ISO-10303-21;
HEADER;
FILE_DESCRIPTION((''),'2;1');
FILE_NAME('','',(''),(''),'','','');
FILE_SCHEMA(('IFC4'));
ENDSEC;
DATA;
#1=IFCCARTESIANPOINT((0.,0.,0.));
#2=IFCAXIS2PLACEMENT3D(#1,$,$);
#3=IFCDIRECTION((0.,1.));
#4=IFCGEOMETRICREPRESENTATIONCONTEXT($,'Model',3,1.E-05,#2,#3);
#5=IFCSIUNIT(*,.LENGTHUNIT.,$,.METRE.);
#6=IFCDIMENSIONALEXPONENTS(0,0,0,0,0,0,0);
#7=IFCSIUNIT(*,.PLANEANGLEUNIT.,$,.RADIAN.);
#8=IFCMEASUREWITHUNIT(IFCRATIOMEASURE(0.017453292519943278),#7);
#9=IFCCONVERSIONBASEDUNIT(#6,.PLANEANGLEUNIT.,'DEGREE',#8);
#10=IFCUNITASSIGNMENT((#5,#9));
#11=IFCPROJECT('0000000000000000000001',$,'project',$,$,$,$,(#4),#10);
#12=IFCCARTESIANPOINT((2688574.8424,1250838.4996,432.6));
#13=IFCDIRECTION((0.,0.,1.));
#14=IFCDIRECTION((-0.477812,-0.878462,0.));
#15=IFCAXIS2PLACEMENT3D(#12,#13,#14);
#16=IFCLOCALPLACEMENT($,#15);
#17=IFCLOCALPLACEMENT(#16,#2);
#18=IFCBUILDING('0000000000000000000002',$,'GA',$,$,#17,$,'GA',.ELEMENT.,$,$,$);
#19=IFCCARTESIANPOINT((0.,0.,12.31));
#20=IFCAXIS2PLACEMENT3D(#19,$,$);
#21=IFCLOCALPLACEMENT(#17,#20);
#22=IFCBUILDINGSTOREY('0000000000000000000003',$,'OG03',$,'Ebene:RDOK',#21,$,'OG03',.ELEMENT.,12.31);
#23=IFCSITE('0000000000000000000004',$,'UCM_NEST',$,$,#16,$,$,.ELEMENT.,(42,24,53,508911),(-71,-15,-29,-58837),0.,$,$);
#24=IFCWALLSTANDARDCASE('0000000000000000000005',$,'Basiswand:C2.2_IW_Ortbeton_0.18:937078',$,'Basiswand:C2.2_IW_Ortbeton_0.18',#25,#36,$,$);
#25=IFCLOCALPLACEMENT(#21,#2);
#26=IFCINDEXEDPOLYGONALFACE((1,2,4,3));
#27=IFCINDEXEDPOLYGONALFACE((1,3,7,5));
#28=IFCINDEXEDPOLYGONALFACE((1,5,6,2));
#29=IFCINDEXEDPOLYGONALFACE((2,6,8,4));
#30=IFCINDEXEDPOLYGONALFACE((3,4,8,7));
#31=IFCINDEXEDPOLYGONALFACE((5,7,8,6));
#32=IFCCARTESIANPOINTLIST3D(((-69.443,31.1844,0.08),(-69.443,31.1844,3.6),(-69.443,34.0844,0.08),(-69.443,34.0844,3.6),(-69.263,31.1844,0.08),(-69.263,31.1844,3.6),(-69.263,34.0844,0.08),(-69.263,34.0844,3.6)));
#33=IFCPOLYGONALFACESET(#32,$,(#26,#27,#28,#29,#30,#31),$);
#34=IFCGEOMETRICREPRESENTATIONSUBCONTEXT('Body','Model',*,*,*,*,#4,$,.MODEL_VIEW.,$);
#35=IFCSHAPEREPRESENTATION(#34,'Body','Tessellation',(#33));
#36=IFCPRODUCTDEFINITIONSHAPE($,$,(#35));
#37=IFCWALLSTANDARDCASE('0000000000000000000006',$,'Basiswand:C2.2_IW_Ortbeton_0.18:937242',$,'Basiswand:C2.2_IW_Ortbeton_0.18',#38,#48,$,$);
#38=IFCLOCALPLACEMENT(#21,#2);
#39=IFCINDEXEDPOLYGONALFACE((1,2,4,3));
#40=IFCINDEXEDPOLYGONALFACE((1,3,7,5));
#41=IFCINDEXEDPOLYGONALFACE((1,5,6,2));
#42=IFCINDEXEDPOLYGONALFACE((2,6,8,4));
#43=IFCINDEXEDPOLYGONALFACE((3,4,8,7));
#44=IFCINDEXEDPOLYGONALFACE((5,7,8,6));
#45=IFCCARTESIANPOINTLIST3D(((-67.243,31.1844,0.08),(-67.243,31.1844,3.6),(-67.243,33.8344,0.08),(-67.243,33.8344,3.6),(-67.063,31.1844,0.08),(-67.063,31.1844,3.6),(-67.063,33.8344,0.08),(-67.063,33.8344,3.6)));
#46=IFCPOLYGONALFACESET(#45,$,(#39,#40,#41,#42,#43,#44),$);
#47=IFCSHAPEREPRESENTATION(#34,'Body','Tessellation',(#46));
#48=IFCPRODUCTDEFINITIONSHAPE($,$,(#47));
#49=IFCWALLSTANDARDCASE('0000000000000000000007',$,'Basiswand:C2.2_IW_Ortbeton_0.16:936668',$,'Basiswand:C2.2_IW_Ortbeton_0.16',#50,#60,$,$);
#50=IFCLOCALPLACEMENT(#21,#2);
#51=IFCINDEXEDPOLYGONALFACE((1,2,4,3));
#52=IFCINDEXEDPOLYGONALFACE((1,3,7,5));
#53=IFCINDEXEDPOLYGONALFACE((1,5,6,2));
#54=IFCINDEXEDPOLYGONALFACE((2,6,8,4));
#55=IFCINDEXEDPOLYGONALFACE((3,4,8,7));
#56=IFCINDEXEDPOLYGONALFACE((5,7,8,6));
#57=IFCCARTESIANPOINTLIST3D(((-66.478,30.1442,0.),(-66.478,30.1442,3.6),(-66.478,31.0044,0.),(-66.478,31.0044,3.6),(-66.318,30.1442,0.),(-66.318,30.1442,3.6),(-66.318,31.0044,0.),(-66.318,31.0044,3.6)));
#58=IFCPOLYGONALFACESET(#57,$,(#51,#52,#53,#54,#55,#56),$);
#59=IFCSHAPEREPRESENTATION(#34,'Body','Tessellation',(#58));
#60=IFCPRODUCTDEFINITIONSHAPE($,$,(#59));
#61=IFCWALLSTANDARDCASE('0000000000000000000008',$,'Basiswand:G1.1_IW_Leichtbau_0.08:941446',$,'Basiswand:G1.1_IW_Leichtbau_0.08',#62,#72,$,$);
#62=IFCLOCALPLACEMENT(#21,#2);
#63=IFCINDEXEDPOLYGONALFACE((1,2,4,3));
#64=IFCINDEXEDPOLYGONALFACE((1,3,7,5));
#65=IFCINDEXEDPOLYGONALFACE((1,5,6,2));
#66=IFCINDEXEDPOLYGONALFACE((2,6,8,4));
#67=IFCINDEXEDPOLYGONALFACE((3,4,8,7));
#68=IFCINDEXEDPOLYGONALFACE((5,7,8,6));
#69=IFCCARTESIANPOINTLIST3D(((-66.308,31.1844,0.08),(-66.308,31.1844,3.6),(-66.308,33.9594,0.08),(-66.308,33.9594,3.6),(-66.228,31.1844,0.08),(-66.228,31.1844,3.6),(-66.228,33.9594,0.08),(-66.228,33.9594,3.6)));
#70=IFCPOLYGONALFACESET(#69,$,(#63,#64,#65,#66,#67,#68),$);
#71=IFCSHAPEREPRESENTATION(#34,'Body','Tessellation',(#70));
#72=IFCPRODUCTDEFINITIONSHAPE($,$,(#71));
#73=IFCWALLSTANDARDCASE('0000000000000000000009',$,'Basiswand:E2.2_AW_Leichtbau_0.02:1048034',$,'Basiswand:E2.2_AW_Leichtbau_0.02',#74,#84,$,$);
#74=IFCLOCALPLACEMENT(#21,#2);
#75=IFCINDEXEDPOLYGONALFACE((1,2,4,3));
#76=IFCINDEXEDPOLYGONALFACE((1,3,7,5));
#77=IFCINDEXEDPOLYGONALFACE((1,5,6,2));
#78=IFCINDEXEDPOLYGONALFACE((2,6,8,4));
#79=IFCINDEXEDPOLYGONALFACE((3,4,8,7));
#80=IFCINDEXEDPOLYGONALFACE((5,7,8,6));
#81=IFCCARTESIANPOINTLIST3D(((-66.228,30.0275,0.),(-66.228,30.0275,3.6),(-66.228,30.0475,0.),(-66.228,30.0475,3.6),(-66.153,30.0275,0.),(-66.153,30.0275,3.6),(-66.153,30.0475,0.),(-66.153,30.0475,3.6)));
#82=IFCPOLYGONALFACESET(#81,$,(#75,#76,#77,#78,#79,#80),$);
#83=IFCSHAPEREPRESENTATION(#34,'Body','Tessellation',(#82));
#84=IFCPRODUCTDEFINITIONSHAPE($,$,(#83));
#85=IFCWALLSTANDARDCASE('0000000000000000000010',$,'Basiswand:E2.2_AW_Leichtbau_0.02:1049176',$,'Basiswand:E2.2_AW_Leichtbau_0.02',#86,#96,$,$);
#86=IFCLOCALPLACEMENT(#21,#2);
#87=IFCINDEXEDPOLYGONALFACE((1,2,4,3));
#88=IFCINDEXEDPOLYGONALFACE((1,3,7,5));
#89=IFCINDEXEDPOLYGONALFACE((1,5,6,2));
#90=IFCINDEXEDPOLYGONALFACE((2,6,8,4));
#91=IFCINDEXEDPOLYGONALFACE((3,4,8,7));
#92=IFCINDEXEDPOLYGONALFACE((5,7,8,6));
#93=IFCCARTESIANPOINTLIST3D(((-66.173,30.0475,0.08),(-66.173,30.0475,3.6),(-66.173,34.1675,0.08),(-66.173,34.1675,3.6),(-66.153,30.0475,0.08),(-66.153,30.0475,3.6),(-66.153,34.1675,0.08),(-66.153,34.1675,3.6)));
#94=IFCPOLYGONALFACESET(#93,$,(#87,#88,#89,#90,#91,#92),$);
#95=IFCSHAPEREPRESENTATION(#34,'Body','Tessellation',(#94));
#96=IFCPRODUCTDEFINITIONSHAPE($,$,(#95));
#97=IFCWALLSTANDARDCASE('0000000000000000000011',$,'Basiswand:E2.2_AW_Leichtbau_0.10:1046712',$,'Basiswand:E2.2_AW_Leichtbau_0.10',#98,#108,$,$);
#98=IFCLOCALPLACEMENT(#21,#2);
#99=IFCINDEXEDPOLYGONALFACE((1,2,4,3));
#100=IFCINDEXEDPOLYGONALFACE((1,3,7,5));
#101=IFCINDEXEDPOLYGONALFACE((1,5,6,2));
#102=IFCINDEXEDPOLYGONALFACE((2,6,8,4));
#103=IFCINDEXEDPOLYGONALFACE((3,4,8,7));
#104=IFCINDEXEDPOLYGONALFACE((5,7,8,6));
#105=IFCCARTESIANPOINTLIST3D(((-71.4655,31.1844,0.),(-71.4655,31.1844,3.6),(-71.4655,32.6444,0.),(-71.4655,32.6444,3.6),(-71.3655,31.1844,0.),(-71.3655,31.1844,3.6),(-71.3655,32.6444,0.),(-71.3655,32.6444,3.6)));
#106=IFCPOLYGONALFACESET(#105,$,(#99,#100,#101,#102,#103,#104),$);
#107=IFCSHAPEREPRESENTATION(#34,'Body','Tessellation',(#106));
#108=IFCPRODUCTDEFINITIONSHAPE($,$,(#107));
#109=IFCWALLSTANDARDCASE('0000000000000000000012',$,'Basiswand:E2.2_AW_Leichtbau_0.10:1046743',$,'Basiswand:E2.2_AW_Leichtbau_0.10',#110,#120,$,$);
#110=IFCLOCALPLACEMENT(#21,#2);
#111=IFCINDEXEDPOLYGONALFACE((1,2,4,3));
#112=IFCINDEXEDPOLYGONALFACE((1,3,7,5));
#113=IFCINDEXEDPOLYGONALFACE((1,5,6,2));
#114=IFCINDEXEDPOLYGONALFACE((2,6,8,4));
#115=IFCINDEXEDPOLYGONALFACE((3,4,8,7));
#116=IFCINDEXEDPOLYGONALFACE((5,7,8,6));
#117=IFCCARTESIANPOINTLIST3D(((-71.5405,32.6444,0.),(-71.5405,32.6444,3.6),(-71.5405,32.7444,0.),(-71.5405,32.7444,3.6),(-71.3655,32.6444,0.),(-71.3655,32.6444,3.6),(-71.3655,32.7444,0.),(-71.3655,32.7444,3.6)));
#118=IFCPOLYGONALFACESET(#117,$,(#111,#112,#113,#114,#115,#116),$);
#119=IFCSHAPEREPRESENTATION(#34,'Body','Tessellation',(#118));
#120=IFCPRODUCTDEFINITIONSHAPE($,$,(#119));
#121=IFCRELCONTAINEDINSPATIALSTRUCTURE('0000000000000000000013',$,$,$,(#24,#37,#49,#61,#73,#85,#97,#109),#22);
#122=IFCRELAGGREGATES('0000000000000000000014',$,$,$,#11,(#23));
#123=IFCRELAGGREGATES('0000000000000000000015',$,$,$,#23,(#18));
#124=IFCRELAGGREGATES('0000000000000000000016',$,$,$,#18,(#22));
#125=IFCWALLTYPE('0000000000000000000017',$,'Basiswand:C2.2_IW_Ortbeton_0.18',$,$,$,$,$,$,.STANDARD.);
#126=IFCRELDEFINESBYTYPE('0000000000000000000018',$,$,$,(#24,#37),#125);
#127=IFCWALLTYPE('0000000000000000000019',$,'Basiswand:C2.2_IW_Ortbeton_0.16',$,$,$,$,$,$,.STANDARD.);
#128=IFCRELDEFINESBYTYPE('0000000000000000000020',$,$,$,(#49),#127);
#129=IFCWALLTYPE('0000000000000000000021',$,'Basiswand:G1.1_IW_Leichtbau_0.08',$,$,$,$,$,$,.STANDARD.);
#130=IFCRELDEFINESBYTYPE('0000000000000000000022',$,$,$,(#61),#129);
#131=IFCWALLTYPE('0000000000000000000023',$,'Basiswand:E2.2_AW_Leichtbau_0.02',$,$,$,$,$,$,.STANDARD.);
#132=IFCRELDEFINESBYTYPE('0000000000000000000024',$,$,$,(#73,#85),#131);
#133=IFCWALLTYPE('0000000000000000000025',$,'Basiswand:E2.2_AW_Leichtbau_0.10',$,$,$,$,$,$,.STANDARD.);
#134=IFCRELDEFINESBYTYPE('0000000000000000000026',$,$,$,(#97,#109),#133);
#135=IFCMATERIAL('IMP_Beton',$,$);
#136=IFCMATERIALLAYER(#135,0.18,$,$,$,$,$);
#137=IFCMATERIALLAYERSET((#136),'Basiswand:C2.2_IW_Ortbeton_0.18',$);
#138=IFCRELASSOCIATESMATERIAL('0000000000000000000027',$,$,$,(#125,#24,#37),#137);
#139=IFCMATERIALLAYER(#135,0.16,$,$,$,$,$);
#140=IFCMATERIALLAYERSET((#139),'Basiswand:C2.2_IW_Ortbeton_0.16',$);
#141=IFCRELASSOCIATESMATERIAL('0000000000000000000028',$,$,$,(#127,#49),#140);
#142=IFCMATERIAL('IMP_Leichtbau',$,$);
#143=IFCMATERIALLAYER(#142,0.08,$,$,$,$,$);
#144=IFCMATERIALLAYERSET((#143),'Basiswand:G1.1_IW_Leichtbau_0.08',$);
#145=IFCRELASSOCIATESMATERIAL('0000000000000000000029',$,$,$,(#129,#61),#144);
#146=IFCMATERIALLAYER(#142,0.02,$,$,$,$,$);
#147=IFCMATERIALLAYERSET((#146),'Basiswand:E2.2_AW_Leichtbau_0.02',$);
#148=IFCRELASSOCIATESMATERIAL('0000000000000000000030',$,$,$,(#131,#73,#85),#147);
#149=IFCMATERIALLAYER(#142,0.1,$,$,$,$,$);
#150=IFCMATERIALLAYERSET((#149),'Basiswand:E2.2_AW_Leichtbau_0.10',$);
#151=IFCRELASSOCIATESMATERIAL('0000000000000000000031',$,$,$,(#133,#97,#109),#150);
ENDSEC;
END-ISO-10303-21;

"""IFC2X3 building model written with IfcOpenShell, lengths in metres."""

from ifc_helpers import new_model, entity, si_unit, converted_unit, direction, frame, frame_2d, origin, place, context, subcontext, project, spatial, polyline, rectangle, extrude, clip, bounded_halfspace, material, layer, layer_set, layer_usage, type_object, element, save


model = new_model("IFC2X3")

# Units and contexts
model_context = context("Model", 3, precision=1e-05, world=origin(), true_north=direction((0.0, 1.0)))
body_context = subcontext(model_context, "Body", "Model", "MODEL_VIEW")
ifc_project = project(units=[si_unit("LENGTHUNIT", "METRE"), converted_unit("PLANEANGLEUNIT", "DEGREE", entity("IfcRatioMeasure", 0.017453292519943278), si_unit("PLANEANGLEUNIT", "RADIAN"), dimensions=[0, 0, 0, 0, 0, 0, 0])], contexts=[model_context])

# Site, building, storey
site_placement = place(None, frame((2688574.8424, 1250838.4996, 432.6), z_axis=(0.0, 0.0, 1.0), x_axis=(-0.477812, -0.878462, 0.0)))
site = spatial("IfcSite", under=ifc_project, at=site_placement, Name="UCM_NEST", CompositionType="ELEMENT", RefLatitude=(42, 24, 53, 508911), RefLongitude=(-71, -15, -29, -58837), RefElevation=0.0)
building_placement = place(site_placement, origin())
building = spatial("IfcBuilding", under=site, at=building_placement, Name="GA", LongName="GA", CompositionType="ELEMENT")
storey_placement = place(building_placement, frame((0.0, 0.0, 12.31)))
storey = spatial("IfcBuildingStorey", under=building, at=storey_placement, Name="OG03", ObjectType="Ebene:RDOK", LongName="OG03", CompositionType="ELEMENT", Elevation=12.31)

# Shared definitions
ifc_material_1 = material(Name="IMP_Beton")

# Walls
ifc_material_2 = material(Name="IMP_Leichtbau")
ifc_layer_1 = layer(ifc_material_1, 0.18)
ifc_layer_set_1 = layer_set([ifc_layer_1], Name="Basiswand:C2.2_IW_Ortbeton_0.18")
ifc_layer_usage_1 = layer_usage(ifc_layer_set_1, "AXIS2", "NEGATIVE", 0.09)
wall_type_1 = type_object("IfcWallType", Name="Basiswand:C2.2_IW_Ortbeton_0.18", PredefinedType="STANDARD", material=ifc_layer_set_1)
wall_1_placement = place(storey_placement, frame((-69.353, 31.1844, 0.08), z_axis=(0.0, 0.0, 1.0), x_axis=(0.0, 1.0, 0.0)))
element("IfcWallStandardCase", 1, at=wall_1_placement, inside=storey, type_object=wall_type_1, material=ifc_layer_usage_1, Name="Basiswand:C2.2_IW_Ortbeton_0.18:937078", ObjectType="Basiswand:C2.2_IW_Ortbeton_0.18", context=body_context, shape_type="Clipping", body=[
    clip(extrude(rectangle(XDim=2.9, YDim=0.18, at=frame_2d((1.45, 0.0), x_axis=(-1.0, 0.0))), origin(), (0.0, 0.0, 1.0), 3.52), bounded_halfspace(frame((2.9, -0.09, 0.0), z_axis=(0.0, 0.0, 1.0), x_axis=(0.0, 1.0, 0.0)), True, frame((2.9, -0.09, 0.0), z_axis=(0.0, 0.0, 1.0), x_axis=(0.0, 1.0, 0.0)), polyline([(0.0, 0.0), (0.18, 0.0), (0.18, 2.9), (0.0, 2.9), (0.0, 0.25), (0.0, 0.0)]))),
])
wall_2_placement = place(storey_placement, frame((-67.153, 33.8344, 0.08), z_axis=(0.0, 0.0, 1.0), x_axis=(0.0, -1.0, 0.0)))
element("IfcWallStandardCase", 2, at=wall_2_placement, inside=storey, type_object=wall_type_1, material=ifc_layer_usage_1, Name="Basiswand:C2.2_IW_Ortbeton_0.18:937242", ObjectType="Basiswand:C2.2_IW_Ortbeton_0.18", context=body_context, shape_type="Clipping", body=[
    clip(extrude(rectangle(XDim=2.65, YDim=0.18, at=frame_2d((1.325, 0.0), x_axis=(-1.0, 0.0))), origin(), (0.0, 0.0, 1.0), 3.52), bounded_halfspace(frame((2.65, -0.09, 0.0), z_axis=(0.0, 0.0, 1.0), x_axis=(0.0, -1.0, 0.0)), True, frame((2.65, -0.09, 0.0), z_axis=(0.0, 0.0, 1.0), x_axis=(0.0, -1.0, 0.0)), polyline([(0.0, 0.0), (-0.18, 0.0), (-0.18, -2.65), (0.0, -2.65), (0.0, 0.0)]))),
])
ifc_layer_2 = layer(ifc_material_1, 0.16)
ifc_layer_set_2 = layer_set([ifc_layer_2], Name="Basiswand:C2.2_IW_Ortbeton_0.16")
ifc_layer_usage_2 = layer_usage(ifc_layer_set_2, "AXIS2", "NEGATIVE", 0.08)
wall_type_2 = type_object("IfcWallType", Name="Basiswand:C2.2_IW_Ortbeton_0.16", PredefinedType="STANDARD", material=ifc_layer_set_2)
wall_3_placement = place(storey_placement, frame((-66.398, 31.0044, 0.0), z_axis=(0.0, 0.0, 1.0), x_axis=(0.0, -1.0, 0.0)))
element("IfcWallStandardCase", 3, at=wall_3_placement, inside=storey, type_object=wall_type_2, material=ifc_layer_usage_2, Name="Basiswand:C2.2_IW_Ortbeton_0.16:936668", ObjectType="Basiswand:C2.2_IW_Ortbeton_0.16", context=body_context, shape_type="SweptSolid", body=[
    extrude(rectangle(XDim=0.8603, YDim=0.16, at=frame_2d((0.4301, 0.0), x_axis=(-1.0, 0.0))), origin(), (0.0, 0.0, 1.0), 3.6),
])
ifc_layer_3 = layer(ifc_material_2, 0.08)
ifc_layer_set_3 = layer_set([ifc_layer_3], Name="Basiswand:G1.1_IW_Leichtbau_0.08")
ifc_layer_usage_3 = layer_usage(ifc_layer_set_3, "AXIS2", "NEGATIVE", 0.04)
wall_type_3 = type_object("IfcWallType", Name="Basiswand:G1.1_IW_Leichtbau_0.08", PredefinedType="STANDARD", material=ifc_layer_set_3)
wall_4_placement = place(storey_placement, frame((-66.268, 33.9594, 0.08), z_axis=(0.0, 0.0, 1.0), x_axis=(0.0, -1.0, 0.0)))
element("IfcWallStandardCase", 4, at=wall_4_placement, inside=storey, type_object=wall_type_3, material=ifc_layer_usage_3, Name="Basiswand:G1.1_IW_Leichtbau_0.08:941446", ObjectType="Basiswand:G1.1_IW_Leichtbau_0.08", context=body_context, shape_type="Clipping", body=[
    clip(extrude(rectangle(XDim=2.775, YDim=0.08, at=frame_2d((1.3875, 0.0), x_axis=(-1.0, 0.0))), origin(), (0.0, 0.0, 1.0), 3.52), bounded_halfspace(frame((2.775, -0.04, 0.0), z_axis=(0.0, 0.0, 1.0), x_axis=(0.0, -1.0, 0.0)), True, frame((2.775, -0.04, 0.0), z_axis=(0.0, 0.0, 1.0), x_axis=(0.0, -1.0, 0.0)), polyline([(0.0, 0.0), (-0.08, 0.0), (-0.08, -2.775), (-0.03, -2.775), (0.0, -2.775), (0.0, 0.0)]))),
])

# Walls
ifc_layer_4 = layer(ifc_material_2, 0.02)
ifc_layer_set_4 = layer_set([ifc_layer_4], Name="Basiswand:E2.2_AW_Leichtbau_0.02")
ifc_layer_usage_4 = layer_usage(ifc_layer_set_4, "AXIS2", "NEGATIVE", 0.01)
wall_type_4 = type_object("IfcWallType", Name="Basiswand:E2.2_AW_Leichtbau_0.02", PredefinedType="STANDARD", material=ifc_layer_set_4)
wall_5_placement = place(storey_placement, frame((-66.228, 30.0375, 0.0)))
element("IfcWallStandardCase", 5, at=wall_5_placement, inside=storey, type_object=wall_type_4, material=ifc_layer_usage_4, Name="Basiswand:E2.2_AW_Leichtbau_0.02:1048034", ObjectType="Basiswand:E2.2_AW_Leichtbau_0.02", context=body_context, shape_type="SweptSolid", body=[
    extrude(rectangle(XDim=0.075, YDim=0.02, at=frame_2d((0.0375, 0.0), x_axis=(-1.0, 0.0))), origin(), (0.0, 0.0, 1.0), 3.6),
])
wall_6_placement = place(storey_placement, frame((-66.163, 30.0475, 0.08), z_axis=(0.0, 0.0, 1.0), x_axis=(0.0, 1.0, 0.0)))
element("IfcWallStandardCase", 6, at=wall_6_placement, inside=storey, type_object=wall_type_4, material=ifc_layer_usage_4, Name="Basiswand:E2.2_AW_Leichtbau_0.02:1049176", ObjectType="Basiswand:E2.2_AW_Leichtbau_0.02", context=body_context, shape_type="Clipping", body=[
    clip(extrude(rectangle(XDim=4.12, YDim=0.02, at=frame_2d((2.06, 0.0), x_axis=(-1.0, 0.0))), origin(), (0.0, 0.0, 1.0), 3.52), bounded_halfspace(frame((4.12, -0.01, 0.0), z_axis=(0.0, 0.0, 1.0), x_axis=(0.0, 1.0, 0.0)), True, frame((4.12, -0.01, 0.0), z_axis=(0.0, 0.0, 1.0), x_axis=(0.0, 1.0, 0.0)), polyline([(0.0, 0.0), (0.02, 0.0), (0.02, 4.12), (0.0, 4.12), (0.0, 0.0)]))),
])
ifc_layer_5 = layer(ifc_material_2, 0.1)
ifc_layer_set_5 = layer_set([ifc_layer_5], Name="Basiswand:E2.2_AW_Leichtbau_0.10")
ifc_layer_usage_5 = layer_usage(ifc_layer_set_5, "AXIS2", "NEGATIVE", 0.05)
wall_type_5 = type_object("IfcWallType", Name="Basiswand:E2.2_AW_Leichtbau_0.10", PredefinedType="STANDARD", material=ifc_layer_set_5)
wall_7_placement = place(storey_placement, frame((-71.4155, 31.1844, 0.0), z_axis=(0.0, 0.0, 1.0), x_axis=(0.0, 1.0, 0.0)))
element("IfcWallStandardCase", 7, at=wall_7_placement, inside=storey, type_object=wall_type_5, material=ifc_layer_usage_5, Name="Basiswand:E2.2_AW_Leichtbau_0.10:1046712", ObjectType="Basiswand:E2.2_AW_Leichtbau_0.10", context=body_context, shape_type="SweptSolid", body=[
    extrude(rectangle(XDim=1.46, YDim=0.1, at=frame_2d((0.73, 0.0), x_axis=(-1.0, 0.0))), origin(), (0.0, 0.0, 1.0), 3.6),
])
wall_8_placement = place(storey_placement, frame((-71.5405, 32.6944, 0.0)))
element("IfcWallStandardCase", 8, at=wall_8_placement, inside=storey, type_object=wall_type_5, material=ifc_layer_usage_5, Name="Basiswand:E2.2_AW_Leichtbau_0.10:1046743", ObjectType="Basiswand:E2.2_AW_Leichtbau_0.10", context=body_context, shape_type="SweptSolid", body=[
    extrude(rectangle(XDim=0.175, YDim=0.1, at=frame_2d((0.0875, 0.0), x_axis=(-1.0, 0.0))), origin(), (0.0, 0.0, 1.0), 3.6),
])

save(model, "model.ifc")
